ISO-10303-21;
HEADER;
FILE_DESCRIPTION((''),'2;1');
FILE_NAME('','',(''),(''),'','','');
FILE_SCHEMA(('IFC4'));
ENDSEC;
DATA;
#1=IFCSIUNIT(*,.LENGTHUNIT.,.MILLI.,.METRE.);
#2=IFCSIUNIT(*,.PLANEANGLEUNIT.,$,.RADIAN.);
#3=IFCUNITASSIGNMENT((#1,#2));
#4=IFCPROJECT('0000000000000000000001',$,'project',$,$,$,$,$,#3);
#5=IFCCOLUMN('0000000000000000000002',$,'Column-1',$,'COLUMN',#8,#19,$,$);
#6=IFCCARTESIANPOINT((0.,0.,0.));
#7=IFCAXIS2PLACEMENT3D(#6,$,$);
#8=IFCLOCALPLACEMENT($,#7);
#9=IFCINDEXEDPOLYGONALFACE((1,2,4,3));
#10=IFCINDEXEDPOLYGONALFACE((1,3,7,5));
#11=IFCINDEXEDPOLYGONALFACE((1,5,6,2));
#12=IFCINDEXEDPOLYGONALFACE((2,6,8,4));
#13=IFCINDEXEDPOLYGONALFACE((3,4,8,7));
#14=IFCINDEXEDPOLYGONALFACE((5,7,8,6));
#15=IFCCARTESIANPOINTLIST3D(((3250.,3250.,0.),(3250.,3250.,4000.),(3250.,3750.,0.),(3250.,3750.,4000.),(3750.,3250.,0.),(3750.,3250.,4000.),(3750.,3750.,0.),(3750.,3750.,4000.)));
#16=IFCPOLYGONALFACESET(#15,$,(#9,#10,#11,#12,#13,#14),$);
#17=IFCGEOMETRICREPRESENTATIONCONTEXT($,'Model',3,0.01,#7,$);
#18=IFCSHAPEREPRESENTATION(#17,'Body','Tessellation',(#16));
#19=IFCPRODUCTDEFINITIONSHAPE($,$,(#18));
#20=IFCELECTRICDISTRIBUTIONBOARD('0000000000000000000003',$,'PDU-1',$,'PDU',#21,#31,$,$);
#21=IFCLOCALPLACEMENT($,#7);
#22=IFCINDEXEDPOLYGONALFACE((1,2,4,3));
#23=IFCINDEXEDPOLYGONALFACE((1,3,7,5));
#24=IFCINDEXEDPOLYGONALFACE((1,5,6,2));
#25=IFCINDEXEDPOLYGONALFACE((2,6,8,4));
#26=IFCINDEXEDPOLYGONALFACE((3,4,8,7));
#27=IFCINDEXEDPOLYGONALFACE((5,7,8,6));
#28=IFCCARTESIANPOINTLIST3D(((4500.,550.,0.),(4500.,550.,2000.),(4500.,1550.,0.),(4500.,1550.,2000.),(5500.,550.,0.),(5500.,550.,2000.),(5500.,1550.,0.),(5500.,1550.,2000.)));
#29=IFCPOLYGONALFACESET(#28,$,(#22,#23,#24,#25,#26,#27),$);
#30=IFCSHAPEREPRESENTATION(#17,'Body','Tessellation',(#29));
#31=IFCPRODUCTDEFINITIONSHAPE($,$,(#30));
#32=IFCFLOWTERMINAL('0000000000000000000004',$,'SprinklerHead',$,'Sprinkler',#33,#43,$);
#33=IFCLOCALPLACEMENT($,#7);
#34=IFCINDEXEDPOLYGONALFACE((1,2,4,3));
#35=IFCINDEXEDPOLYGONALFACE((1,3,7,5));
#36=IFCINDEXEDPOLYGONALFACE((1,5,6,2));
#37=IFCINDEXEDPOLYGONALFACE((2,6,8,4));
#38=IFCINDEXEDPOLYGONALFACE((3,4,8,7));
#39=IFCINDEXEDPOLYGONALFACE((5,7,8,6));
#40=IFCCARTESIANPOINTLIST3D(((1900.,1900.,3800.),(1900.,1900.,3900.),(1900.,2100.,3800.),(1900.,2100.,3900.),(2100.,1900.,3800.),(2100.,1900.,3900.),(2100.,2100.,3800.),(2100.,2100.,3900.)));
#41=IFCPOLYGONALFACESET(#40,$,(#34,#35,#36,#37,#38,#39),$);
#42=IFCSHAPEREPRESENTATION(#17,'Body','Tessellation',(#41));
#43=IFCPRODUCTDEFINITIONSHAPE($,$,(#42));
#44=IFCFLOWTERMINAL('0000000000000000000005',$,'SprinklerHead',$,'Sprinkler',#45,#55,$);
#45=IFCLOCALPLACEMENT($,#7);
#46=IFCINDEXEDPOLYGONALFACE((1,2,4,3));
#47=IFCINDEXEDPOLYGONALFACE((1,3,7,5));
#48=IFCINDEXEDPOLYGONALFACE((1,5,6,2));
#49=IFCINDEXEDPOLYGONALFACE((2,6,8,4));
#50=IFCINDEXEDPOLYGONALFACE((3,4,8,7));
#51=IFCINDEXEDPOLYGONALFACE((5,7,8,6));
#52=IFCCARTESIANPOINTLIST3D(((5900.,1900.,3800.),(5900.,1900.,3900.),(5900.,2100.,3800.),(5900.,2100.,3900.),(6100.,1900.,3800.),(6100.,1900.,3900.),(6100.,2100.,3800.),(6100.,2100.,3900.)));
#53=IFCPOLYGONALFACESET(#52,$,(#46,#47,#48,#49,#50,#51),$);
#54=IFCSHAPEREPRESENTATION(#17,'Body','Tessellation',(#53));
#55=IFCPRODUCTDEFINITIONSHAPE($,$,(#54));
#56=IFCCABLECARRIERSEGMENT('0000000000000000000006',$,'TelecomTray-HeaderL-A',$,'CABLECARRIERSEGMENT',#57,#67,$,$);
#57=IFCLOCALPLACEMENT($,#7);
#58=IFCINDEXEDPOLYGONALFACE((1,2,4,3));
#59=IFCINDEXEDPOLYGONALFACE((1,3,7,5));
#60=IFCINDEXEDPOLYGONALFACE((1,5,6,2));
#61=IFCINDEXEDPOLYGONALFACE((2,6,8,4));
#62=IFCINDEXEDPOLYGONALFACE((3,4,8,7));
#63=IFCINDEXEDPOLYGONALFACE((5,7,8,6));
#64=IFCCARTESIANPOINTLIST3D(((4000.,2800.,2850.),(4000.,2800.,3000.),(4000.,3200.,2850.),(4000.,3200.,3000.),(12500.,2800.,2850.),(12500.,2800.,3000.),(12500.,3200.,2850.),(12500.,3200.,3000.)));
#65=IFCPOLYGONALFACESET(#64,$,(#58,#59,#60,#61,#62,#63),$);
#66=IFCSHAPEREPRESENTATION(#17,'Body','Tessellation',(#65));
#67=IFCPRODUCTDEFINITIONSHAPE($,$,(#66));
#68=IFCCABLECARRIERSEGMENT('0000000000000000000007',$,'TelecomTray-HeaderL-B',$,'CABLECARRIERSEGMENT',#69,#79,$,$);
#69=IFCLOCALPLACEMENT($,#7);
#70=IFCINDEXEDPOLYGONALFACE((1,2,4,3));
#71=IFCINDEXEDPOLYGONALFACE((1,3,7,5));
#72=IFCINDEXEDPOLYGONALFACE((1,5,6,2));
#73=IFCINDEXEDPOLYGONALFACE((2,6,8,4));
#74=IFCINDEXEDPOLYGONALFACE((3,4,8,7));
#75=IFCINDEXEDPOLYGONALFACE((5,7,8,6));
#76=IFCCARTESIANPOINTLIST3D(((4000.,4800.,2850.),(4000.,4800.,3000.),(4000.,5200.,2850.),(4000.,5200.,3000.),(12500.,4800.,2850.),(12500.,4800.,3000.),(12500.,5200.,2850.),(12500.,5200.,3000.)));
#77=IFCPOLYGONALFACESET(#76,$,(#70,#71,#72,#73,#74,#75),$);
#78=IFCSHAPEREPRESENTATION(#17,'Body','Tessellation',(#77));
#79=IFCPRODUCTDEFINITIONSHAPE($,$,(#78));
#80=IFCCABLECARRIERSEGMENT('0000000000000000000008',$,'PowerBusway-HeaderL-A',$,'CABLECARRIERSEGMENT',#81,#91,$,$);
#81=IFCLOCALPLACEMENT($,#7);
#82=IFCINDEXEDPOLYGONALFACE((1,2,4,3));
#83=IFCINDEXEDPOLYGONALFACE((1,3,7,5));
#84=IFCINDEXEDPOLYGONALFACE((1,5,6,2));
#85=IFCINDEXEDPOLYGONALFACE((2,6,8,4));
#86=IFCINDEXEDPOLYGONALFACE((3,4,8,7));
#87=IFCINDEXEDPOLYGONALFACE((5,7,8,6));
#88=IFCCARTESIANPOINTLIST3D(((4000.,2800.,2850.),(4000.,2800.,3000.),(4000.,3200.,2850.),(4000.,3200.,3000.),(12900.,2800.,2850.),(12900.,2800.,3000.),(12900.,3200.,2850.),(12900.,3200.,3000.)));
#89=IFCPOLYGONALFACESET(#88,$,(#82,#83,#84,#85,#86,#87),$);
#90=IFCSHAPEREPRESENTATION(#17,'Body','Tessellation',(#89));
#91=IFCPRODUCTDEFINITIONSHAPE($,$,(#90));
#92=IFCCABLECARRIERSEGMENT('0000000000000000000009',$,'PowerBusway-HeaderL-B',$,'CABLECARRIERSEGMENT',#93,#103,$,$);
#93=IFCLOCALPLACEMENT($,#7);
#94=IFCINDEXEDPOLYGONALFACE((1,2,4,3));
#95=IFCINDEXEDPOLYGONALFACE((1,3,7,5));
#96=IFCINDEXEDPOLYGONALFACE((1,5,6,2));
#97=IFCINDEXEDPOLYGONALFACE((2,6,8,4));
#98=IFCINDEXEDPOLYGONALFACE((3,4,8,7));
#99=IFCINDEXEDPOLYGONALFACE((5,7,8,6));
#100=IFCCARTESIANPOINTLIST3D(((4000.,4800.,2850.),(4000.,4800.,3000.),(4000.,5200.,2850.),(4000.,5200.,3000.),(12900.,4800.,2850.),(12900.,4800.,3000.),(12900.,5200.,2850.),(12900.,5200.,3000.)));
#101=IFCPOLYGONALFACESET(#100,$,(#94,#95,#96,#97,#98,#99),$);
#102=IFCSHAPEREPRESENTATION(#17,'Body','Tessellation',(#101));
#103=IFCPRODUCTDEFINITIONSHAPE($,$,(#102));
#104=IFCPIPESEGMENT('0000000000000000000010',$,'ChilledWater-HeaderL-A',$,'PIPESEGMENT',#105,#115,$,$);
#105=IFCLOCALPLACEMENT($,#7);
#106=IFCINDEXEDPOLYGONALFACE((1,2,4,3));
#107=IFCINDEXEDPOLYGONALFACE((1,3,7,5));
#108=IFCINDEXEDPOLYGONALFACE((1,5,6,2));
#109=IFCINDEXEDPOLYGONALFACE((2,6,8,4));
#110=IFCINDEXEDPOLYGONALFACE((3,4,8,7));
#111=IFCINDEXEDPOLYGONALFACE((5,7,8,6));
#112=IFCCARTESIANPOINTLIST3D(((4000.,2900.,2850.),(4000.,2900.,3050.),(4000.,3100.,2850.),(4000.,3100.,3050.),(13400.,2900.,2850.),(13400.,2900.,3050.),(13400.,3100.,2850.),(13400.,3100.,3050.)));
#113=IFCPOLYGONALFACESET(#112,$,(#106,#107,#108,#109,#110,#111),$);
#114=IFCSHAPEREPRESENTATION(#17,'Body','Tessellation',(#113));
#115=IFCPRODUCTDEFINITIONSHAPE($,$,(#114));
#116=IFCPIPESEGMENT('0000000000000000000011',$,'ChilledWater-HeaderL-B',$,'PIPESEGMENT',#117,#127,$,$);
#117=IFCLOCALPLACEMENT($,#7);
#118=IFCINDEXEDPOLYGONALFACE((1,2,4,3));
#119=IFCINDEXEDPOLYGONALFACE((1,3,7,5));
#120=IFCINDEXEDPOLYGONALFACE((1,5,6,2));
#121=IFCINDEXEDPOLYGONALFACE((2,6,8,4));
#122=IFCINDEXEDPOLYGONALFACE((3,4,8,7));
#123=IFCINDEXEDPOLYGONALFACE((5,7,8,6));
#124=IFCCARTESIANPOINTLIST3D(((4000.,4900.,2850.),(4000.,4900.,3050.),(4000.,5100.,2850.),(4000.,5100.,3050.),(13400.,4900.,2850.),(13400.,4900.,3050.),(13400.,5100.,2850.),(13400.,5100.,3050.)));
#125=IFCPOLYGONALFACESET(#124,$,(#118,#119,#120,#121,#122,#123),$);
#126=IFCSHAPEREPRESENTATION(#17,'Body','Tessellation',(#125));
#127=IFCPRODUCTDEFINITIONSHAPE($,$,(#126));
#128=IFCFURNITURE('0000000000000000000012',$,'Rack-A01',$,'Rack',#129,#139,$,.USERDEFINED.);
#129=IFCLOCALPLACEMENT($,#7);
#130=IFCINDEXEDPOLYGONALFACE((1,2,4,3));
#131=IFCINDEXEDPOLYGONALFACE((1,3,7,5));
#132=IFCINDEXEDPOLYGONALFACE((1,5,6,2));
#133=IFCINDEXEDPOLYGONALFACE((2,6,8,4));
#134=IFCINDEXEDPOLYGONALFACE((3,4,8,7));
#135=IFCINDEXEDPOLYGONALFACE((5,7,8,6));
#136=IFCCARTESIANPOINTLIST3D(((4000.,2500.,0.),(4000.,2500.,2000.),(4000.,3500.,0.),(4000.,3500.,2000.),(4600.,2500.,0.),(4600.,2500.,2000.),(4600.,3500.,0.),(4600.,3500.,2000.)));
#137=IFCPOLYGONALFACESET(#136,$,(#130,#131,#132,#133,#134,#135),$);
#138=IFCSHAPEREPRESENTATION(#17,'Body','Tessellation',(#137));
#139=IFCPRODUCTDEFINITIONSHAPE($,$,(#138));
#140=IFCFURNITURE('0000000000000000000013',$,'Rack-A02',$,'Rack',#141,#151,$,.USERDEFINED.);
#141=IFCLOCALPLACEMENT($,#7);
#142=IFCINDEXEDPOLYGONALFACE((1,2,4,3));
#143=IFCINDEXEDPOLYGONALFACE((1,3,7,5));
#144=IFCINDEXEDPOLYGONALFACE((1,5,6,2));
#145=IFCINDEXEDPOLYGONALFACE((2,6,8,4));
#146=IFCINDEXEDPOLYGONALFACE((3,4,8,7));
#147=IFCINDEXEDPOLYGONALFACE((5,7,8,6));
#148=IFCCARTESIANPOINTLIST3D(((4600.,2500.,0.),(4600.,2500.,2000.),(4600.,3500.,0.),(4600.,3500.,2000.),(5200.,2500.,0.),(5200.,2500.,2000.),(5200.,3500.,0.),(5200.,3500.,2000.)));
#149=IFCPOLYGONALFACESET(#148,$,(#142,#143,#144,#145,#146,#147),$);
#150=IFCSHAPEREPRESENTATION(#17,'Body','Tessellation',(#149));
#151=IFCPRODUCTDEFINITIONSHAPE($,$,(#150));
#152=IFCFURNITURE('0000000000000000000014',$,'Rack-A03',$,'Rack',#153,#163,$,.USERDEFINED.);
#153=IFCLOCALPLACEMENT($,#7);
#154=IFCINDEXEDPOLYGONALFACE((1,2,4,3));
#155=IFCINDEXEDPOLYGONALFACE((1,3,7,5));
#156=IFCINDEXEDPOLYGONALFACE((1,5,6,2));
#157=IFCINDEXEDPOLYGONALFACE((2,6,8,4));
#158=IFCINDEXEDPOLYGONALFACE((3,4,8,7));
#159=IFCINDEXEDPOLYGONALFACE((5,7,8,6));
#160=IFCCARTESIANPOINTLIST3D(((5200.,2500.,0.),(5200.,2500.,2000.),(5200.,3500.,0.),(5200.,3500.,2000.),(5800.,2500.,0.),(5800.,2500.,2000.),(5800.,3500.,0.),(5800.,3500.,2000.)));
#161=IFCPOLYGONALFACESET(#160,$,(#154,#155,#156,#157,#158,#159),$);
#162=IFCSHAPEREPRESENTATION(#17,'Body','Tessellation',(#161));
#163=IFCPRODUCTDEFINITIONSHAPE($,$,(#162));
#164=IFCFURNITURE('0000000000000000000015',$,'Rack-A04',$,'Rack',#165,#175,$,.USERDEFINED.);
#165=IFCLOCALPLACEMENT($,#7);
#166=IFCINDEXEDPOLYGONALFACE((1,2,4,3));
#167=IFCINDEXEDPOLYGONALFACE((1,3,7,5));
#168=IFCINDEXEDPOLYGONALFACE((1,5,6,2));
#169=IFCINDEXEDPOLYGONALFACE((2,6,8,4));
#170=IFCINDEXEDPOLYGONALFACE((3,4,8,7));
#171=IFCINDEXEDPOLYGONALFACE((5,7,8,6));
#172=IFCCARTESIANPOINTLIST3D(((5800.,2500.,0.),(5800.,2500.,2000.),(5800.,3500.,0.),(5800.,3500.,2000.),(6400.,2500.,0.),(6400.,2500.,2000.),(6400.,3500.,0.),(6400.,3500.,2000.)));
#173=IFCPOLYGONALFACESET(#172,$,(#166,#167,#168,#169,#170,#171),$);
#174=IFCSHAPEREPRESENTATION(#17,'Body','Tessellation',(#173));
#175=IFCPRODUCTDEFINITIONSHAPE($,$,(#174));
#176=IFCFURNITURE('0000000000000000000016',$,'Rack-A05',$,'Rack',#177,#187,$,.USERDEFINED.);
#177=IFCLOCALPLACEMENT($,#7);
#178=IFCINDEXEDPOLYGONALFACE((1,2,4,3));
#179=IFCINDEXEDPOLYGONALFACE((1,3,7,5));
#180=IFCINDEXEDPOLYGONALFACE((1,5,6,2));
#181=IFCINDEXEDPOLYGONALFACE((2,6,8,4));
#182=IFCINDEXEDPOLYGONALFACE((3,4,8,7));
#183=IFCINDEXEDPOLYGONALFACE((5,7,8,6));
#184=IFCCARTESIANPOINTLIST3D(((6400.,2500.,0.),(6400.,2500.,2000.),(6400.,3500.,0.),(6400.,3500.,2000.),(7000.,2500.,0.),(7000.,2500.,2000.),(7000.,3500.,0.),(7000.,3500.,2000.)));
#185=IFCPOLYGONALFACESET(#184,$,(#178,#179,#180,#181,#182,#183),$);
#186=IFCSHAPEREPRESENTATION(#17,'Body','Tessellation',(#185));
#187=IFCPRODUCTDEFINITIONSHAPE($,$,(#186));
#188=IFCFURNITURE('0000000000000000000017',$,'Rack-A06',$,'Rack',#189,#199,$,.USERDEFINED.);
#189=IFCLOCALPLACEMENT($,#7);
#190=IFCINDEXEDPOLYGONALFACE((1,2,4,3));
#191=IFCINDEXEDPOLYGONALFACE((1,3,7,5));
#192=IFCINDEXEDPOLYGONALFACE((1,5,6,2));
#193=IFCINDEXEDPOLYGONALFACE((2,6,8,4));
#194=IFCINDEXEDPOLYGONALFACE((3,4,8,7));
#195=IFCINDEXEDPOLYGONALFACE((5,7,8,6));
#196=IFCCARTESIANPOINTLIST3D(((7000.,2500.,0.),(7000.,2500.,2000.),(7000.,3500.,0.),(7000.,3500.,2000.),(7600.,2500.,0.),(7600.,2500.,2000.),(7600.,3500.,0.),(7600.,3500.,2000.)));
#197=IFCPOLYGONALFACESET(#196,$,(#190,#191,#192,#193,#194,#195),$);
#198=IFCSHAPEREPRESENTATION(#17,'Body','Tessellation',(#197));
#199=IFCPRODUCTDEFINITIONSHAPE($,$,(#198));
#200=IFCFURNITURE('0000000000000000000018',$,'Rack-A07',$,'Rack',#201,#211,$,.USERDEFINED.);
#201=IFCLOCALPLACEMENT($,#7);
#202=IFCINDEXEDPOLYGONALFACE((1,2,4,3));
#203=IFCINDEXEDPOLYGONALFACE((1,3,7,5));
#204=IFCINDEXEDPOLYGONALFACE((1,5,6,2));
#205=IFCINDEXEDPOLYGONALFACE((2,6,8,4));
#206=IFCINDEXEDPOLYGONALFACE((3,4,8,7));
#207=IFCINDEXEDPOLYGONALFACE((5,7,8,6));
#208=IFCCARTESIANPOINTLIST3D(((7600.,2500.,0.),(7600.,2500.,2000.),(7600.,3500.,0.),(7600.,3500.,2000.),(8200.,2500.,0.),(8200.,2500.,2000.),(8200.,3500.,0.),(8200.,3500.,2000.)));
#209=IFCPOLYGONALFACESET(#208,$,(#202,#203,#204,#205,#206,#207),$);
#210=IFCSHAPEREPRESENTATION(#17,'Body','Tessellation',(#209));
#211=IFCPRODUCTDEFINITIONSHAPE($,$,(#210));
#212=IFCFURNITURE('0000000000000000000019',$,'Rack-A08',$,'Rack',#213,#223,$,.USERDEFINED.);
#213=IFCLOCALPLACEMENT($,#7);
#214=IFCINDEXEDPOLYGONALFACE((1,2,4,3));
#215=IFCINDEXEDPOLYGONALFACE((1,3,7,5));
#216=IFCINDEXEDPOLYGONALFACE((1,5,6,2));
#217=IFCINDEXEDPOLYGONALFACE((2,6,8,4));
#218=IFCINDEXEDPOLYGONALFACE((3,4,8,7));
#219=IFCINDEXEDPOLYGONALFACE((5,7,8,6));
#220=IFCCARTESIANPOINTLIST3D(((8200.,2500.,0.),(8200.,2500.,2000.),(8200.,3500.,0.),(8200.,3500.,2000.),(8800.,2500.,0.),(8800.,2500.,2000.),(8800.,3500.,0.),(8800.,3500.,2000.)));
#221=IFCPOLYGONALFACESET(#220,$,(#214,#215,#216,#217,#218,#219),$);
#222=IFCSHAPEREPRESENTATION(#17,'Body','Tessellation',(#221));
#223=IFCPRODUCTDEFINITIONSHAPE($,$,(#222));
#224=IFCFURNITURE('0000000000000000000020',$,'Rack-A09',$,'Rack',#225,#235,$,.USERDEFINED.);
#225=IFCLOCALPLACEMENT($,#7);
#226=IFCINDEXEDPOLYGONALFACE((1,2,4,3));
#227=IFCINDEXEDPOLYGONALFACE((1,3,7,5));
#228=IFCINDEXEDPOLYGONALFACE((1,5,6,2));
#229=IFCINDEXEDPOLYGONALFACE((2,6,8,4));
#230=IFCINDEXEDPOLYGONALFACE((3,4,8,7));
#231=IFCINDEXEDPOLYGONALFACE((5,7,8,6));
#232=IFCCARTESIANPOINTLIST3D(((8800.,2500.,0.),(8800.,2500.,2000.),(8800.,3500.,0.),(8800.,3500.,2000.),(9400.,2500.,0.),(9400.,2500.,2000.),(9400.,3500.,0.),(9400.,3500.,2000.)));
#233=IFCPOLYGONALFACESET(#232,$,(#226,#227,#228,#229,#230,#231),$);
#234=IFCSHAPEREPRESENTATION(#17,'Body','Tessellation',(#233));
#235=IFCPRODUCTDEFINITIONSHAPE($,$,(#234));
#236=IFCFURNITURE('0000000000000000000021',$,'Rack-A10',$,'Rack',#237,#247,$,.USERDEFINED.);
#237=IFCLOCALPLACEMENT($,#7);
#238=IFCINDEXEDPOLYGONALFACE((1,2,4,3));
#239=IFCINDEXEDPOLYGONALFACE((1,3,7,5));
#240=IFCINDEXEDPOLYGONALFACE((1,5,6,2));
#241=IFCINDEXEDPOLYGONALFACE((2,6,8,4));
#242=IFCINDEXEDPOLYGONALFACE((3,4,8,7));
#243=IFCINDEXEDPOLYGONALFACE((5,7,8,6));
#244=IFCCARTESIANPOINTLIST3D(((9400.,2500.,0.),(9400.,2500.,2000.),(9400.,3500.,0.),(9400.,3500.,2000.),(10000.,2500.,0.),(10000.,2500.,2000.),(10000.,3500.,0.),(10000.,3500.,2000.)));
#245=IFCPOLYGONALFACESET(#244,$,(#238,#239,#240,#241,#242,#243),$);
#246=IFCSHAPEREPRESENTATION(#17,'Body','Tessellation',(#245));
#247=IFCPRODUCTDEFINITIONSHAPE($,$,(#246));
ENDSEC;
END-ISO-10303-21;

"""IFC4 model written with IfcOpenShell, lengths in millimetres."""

from ifc_helpers import new_model, si_unit, frame, origin, place, context, project, polyline, outline, extrude, element, save


model = new_model("IFC4")

# Units and contexts
model_context = context("Model", 3, precision=0.01, world=origin())
ifc_project = project(units=[si_unit("LENGTHUNIT", "METRE", prefix="MILLI"), si_unit("PLANEANGLEUNIT", "RADIAN")])

# Column
column_placement = place(None, frame((3500.0, 3500.0, 0.0)))
element("IfcColumn", 1, at=column_placement, Name="Column-1", ObjectType="COLUMN", context=model_context, shape_type="SweptSolid", body=[
    extrude(outline(polyline([(-250.0, -250.0), (250.0, -250.0), (250.0, 250.0), (-250.0, 250.0), (-250.0, -250.0)])), origin(), (0.0, 0.0, 1.0), 4000.0),
])

# Electric distribution board
electric_distribution_board_placement = place(None, frame((5000.0, 1050.0, 0.0)))
element("IfcElectricDistributionBoard", 2, at=electric_distribution_board_placement, Name="PDU-1", ObjectType="PDU", context=model_context, shape_type="SweptSolid", body=[
    extrude(outline(polyline([(-500.0, -500.0), (500.0, -500.0), (500.0, 500.0), (-500.0, 500.0), (-500.0, -500.0)])), origin(), (0.0, 0.0, 1.0), 2000.0),
])

# Flow terminals
for number, where, name in (
    (3, (2000.0, 2000.0, 3800.0), "SprinklerHead"),
    (4, (6000.0, 2000.0, 3800.0), "SprinklerHead"),
):
    element("IfcFlowTerminal", number, at=place(None, frame(where)), Name=name, ObjectType="Sprinkler", context=model_context, shape_type="SweptSolid", body=[
        extrude(outline(polyline([(-100.0, -100.0), (100.0, -100.0), (100.0, 100.0), (-100.0, 100.0), (-100.0, -100.0)])), origin(), (0.0, 0.0, 1.0), 100.0),
    ])

# Cable carrier segments
for number, where, name in (
    (5, (8250.0, 3000.0, 2850.0), "TelecomTray-HeaderL-A"),
    (6, (8250.0, 5000.0, 2850.0), "TelecomTray-HeaderL-B"),
):
    element("IfcCableCarrierSegment", number, at=place(None, frame(where)), Name=name, ObjectType="CABLECARRIERSEGMENT", context=model_context, shape_type="SweptSolid", body=[
        extrude(outline(polyline([(-4250.0, -200.0), (4250.0, -200.0), (4250.0, 200.0), (-4250.0, 200.0), (-4250.0, -200.0)])), origin(), (0.0, 0.0, 1.0), 150.0),
    ])
for number, where, name in (
    (7, (8450.0, 3000.0, 2850.0), "PowerBusway-HeaderL-A"),
    (8, (8450.0, 5000.0, 2850.0), "PowerBusway-HeaderL-B"),
):
    element("IfcCableCarrierSegment", number, at=place(None, frame(where)), Name=name, ObjectType="CABLECARRIERSEGMENT", context=model_context, shape_type="SweptSolid", body=[
        extrude(outline(polyline([(-4450.0, -200.0), (4450.0, -200.0), (4450.0, 200.0), (-4450.0, 200.0), (-4450.0, -200.0)])), origin(), (0.0, 0.0, 1.0), 150.0),
    ])

# Pipe segments
for number, where, name in (
    (9, (8700.0, 3000.0, 2850.0), "ChilledWater-HeaderL-A"),
    (10, (8700.0, 5000.0, 2850.0), "ChilledWater-HeaderL-B"),
):
    element("IfcPipeSegment", number, at=place(None, frame(where)), Name=name, ObjectType="PIPESEGMENT", context=model_context, shape_type="SweptSolid", body=[
        extrude(outline(polyline([(-4700.0, -100.0), (4700.0, -100.0), (4700.0, 100.0), (-4700.0, 100.0), (-4700.0, -100.0)])), origin(), (0.0, 0.0, 1.0), 200.0),
    ])

# Furniture
for number, where, name in (
    (11, (4300.0, 3000.0, 0.0), "Rack-A01"),
    (12, (4900.0, 3000.0, 0.0), "Rack-A02"),
    (13, (5500.0, 3000.0, 0.0), "Rack-A03"),
    (14, (6100.0, 3000.0, 0.0), "Rack-A04"),
    (15, (6700.0, 3000.0, 0.0), "Rack-A05"),
    (16, (7300.0, 3000.0, 0.0), "Rack-A06"),
    (17, (7900.0, 3000.0, 0.0), "Rack-A07"),
    (18, (8500.0, 3000.0, 0.0), "Rack-A08"),
    (19, (9100.0, 3000.0, 0.0), "Rack-A09"),
    (20, (9700.0, 3000.0, 0.0), "Rack-A10"),
):
    element("IfcFurniture", number, at=place(None, frame(where)), Name=name, ObjectType="Rack", PredefinedType="USERDEFINED", context=model_context, shape_type="SweptSolid", body=[
        extrude(outline(polyline([(-300.0, -500.0), (300.0, -500.0), (300.0, 500.0), (-300.0, 500.0), (-300.0, -500.0)])), origin(), (0.0, 0.0, 1.0), 2000.0),
    ])

save(model, "model.ifc")
